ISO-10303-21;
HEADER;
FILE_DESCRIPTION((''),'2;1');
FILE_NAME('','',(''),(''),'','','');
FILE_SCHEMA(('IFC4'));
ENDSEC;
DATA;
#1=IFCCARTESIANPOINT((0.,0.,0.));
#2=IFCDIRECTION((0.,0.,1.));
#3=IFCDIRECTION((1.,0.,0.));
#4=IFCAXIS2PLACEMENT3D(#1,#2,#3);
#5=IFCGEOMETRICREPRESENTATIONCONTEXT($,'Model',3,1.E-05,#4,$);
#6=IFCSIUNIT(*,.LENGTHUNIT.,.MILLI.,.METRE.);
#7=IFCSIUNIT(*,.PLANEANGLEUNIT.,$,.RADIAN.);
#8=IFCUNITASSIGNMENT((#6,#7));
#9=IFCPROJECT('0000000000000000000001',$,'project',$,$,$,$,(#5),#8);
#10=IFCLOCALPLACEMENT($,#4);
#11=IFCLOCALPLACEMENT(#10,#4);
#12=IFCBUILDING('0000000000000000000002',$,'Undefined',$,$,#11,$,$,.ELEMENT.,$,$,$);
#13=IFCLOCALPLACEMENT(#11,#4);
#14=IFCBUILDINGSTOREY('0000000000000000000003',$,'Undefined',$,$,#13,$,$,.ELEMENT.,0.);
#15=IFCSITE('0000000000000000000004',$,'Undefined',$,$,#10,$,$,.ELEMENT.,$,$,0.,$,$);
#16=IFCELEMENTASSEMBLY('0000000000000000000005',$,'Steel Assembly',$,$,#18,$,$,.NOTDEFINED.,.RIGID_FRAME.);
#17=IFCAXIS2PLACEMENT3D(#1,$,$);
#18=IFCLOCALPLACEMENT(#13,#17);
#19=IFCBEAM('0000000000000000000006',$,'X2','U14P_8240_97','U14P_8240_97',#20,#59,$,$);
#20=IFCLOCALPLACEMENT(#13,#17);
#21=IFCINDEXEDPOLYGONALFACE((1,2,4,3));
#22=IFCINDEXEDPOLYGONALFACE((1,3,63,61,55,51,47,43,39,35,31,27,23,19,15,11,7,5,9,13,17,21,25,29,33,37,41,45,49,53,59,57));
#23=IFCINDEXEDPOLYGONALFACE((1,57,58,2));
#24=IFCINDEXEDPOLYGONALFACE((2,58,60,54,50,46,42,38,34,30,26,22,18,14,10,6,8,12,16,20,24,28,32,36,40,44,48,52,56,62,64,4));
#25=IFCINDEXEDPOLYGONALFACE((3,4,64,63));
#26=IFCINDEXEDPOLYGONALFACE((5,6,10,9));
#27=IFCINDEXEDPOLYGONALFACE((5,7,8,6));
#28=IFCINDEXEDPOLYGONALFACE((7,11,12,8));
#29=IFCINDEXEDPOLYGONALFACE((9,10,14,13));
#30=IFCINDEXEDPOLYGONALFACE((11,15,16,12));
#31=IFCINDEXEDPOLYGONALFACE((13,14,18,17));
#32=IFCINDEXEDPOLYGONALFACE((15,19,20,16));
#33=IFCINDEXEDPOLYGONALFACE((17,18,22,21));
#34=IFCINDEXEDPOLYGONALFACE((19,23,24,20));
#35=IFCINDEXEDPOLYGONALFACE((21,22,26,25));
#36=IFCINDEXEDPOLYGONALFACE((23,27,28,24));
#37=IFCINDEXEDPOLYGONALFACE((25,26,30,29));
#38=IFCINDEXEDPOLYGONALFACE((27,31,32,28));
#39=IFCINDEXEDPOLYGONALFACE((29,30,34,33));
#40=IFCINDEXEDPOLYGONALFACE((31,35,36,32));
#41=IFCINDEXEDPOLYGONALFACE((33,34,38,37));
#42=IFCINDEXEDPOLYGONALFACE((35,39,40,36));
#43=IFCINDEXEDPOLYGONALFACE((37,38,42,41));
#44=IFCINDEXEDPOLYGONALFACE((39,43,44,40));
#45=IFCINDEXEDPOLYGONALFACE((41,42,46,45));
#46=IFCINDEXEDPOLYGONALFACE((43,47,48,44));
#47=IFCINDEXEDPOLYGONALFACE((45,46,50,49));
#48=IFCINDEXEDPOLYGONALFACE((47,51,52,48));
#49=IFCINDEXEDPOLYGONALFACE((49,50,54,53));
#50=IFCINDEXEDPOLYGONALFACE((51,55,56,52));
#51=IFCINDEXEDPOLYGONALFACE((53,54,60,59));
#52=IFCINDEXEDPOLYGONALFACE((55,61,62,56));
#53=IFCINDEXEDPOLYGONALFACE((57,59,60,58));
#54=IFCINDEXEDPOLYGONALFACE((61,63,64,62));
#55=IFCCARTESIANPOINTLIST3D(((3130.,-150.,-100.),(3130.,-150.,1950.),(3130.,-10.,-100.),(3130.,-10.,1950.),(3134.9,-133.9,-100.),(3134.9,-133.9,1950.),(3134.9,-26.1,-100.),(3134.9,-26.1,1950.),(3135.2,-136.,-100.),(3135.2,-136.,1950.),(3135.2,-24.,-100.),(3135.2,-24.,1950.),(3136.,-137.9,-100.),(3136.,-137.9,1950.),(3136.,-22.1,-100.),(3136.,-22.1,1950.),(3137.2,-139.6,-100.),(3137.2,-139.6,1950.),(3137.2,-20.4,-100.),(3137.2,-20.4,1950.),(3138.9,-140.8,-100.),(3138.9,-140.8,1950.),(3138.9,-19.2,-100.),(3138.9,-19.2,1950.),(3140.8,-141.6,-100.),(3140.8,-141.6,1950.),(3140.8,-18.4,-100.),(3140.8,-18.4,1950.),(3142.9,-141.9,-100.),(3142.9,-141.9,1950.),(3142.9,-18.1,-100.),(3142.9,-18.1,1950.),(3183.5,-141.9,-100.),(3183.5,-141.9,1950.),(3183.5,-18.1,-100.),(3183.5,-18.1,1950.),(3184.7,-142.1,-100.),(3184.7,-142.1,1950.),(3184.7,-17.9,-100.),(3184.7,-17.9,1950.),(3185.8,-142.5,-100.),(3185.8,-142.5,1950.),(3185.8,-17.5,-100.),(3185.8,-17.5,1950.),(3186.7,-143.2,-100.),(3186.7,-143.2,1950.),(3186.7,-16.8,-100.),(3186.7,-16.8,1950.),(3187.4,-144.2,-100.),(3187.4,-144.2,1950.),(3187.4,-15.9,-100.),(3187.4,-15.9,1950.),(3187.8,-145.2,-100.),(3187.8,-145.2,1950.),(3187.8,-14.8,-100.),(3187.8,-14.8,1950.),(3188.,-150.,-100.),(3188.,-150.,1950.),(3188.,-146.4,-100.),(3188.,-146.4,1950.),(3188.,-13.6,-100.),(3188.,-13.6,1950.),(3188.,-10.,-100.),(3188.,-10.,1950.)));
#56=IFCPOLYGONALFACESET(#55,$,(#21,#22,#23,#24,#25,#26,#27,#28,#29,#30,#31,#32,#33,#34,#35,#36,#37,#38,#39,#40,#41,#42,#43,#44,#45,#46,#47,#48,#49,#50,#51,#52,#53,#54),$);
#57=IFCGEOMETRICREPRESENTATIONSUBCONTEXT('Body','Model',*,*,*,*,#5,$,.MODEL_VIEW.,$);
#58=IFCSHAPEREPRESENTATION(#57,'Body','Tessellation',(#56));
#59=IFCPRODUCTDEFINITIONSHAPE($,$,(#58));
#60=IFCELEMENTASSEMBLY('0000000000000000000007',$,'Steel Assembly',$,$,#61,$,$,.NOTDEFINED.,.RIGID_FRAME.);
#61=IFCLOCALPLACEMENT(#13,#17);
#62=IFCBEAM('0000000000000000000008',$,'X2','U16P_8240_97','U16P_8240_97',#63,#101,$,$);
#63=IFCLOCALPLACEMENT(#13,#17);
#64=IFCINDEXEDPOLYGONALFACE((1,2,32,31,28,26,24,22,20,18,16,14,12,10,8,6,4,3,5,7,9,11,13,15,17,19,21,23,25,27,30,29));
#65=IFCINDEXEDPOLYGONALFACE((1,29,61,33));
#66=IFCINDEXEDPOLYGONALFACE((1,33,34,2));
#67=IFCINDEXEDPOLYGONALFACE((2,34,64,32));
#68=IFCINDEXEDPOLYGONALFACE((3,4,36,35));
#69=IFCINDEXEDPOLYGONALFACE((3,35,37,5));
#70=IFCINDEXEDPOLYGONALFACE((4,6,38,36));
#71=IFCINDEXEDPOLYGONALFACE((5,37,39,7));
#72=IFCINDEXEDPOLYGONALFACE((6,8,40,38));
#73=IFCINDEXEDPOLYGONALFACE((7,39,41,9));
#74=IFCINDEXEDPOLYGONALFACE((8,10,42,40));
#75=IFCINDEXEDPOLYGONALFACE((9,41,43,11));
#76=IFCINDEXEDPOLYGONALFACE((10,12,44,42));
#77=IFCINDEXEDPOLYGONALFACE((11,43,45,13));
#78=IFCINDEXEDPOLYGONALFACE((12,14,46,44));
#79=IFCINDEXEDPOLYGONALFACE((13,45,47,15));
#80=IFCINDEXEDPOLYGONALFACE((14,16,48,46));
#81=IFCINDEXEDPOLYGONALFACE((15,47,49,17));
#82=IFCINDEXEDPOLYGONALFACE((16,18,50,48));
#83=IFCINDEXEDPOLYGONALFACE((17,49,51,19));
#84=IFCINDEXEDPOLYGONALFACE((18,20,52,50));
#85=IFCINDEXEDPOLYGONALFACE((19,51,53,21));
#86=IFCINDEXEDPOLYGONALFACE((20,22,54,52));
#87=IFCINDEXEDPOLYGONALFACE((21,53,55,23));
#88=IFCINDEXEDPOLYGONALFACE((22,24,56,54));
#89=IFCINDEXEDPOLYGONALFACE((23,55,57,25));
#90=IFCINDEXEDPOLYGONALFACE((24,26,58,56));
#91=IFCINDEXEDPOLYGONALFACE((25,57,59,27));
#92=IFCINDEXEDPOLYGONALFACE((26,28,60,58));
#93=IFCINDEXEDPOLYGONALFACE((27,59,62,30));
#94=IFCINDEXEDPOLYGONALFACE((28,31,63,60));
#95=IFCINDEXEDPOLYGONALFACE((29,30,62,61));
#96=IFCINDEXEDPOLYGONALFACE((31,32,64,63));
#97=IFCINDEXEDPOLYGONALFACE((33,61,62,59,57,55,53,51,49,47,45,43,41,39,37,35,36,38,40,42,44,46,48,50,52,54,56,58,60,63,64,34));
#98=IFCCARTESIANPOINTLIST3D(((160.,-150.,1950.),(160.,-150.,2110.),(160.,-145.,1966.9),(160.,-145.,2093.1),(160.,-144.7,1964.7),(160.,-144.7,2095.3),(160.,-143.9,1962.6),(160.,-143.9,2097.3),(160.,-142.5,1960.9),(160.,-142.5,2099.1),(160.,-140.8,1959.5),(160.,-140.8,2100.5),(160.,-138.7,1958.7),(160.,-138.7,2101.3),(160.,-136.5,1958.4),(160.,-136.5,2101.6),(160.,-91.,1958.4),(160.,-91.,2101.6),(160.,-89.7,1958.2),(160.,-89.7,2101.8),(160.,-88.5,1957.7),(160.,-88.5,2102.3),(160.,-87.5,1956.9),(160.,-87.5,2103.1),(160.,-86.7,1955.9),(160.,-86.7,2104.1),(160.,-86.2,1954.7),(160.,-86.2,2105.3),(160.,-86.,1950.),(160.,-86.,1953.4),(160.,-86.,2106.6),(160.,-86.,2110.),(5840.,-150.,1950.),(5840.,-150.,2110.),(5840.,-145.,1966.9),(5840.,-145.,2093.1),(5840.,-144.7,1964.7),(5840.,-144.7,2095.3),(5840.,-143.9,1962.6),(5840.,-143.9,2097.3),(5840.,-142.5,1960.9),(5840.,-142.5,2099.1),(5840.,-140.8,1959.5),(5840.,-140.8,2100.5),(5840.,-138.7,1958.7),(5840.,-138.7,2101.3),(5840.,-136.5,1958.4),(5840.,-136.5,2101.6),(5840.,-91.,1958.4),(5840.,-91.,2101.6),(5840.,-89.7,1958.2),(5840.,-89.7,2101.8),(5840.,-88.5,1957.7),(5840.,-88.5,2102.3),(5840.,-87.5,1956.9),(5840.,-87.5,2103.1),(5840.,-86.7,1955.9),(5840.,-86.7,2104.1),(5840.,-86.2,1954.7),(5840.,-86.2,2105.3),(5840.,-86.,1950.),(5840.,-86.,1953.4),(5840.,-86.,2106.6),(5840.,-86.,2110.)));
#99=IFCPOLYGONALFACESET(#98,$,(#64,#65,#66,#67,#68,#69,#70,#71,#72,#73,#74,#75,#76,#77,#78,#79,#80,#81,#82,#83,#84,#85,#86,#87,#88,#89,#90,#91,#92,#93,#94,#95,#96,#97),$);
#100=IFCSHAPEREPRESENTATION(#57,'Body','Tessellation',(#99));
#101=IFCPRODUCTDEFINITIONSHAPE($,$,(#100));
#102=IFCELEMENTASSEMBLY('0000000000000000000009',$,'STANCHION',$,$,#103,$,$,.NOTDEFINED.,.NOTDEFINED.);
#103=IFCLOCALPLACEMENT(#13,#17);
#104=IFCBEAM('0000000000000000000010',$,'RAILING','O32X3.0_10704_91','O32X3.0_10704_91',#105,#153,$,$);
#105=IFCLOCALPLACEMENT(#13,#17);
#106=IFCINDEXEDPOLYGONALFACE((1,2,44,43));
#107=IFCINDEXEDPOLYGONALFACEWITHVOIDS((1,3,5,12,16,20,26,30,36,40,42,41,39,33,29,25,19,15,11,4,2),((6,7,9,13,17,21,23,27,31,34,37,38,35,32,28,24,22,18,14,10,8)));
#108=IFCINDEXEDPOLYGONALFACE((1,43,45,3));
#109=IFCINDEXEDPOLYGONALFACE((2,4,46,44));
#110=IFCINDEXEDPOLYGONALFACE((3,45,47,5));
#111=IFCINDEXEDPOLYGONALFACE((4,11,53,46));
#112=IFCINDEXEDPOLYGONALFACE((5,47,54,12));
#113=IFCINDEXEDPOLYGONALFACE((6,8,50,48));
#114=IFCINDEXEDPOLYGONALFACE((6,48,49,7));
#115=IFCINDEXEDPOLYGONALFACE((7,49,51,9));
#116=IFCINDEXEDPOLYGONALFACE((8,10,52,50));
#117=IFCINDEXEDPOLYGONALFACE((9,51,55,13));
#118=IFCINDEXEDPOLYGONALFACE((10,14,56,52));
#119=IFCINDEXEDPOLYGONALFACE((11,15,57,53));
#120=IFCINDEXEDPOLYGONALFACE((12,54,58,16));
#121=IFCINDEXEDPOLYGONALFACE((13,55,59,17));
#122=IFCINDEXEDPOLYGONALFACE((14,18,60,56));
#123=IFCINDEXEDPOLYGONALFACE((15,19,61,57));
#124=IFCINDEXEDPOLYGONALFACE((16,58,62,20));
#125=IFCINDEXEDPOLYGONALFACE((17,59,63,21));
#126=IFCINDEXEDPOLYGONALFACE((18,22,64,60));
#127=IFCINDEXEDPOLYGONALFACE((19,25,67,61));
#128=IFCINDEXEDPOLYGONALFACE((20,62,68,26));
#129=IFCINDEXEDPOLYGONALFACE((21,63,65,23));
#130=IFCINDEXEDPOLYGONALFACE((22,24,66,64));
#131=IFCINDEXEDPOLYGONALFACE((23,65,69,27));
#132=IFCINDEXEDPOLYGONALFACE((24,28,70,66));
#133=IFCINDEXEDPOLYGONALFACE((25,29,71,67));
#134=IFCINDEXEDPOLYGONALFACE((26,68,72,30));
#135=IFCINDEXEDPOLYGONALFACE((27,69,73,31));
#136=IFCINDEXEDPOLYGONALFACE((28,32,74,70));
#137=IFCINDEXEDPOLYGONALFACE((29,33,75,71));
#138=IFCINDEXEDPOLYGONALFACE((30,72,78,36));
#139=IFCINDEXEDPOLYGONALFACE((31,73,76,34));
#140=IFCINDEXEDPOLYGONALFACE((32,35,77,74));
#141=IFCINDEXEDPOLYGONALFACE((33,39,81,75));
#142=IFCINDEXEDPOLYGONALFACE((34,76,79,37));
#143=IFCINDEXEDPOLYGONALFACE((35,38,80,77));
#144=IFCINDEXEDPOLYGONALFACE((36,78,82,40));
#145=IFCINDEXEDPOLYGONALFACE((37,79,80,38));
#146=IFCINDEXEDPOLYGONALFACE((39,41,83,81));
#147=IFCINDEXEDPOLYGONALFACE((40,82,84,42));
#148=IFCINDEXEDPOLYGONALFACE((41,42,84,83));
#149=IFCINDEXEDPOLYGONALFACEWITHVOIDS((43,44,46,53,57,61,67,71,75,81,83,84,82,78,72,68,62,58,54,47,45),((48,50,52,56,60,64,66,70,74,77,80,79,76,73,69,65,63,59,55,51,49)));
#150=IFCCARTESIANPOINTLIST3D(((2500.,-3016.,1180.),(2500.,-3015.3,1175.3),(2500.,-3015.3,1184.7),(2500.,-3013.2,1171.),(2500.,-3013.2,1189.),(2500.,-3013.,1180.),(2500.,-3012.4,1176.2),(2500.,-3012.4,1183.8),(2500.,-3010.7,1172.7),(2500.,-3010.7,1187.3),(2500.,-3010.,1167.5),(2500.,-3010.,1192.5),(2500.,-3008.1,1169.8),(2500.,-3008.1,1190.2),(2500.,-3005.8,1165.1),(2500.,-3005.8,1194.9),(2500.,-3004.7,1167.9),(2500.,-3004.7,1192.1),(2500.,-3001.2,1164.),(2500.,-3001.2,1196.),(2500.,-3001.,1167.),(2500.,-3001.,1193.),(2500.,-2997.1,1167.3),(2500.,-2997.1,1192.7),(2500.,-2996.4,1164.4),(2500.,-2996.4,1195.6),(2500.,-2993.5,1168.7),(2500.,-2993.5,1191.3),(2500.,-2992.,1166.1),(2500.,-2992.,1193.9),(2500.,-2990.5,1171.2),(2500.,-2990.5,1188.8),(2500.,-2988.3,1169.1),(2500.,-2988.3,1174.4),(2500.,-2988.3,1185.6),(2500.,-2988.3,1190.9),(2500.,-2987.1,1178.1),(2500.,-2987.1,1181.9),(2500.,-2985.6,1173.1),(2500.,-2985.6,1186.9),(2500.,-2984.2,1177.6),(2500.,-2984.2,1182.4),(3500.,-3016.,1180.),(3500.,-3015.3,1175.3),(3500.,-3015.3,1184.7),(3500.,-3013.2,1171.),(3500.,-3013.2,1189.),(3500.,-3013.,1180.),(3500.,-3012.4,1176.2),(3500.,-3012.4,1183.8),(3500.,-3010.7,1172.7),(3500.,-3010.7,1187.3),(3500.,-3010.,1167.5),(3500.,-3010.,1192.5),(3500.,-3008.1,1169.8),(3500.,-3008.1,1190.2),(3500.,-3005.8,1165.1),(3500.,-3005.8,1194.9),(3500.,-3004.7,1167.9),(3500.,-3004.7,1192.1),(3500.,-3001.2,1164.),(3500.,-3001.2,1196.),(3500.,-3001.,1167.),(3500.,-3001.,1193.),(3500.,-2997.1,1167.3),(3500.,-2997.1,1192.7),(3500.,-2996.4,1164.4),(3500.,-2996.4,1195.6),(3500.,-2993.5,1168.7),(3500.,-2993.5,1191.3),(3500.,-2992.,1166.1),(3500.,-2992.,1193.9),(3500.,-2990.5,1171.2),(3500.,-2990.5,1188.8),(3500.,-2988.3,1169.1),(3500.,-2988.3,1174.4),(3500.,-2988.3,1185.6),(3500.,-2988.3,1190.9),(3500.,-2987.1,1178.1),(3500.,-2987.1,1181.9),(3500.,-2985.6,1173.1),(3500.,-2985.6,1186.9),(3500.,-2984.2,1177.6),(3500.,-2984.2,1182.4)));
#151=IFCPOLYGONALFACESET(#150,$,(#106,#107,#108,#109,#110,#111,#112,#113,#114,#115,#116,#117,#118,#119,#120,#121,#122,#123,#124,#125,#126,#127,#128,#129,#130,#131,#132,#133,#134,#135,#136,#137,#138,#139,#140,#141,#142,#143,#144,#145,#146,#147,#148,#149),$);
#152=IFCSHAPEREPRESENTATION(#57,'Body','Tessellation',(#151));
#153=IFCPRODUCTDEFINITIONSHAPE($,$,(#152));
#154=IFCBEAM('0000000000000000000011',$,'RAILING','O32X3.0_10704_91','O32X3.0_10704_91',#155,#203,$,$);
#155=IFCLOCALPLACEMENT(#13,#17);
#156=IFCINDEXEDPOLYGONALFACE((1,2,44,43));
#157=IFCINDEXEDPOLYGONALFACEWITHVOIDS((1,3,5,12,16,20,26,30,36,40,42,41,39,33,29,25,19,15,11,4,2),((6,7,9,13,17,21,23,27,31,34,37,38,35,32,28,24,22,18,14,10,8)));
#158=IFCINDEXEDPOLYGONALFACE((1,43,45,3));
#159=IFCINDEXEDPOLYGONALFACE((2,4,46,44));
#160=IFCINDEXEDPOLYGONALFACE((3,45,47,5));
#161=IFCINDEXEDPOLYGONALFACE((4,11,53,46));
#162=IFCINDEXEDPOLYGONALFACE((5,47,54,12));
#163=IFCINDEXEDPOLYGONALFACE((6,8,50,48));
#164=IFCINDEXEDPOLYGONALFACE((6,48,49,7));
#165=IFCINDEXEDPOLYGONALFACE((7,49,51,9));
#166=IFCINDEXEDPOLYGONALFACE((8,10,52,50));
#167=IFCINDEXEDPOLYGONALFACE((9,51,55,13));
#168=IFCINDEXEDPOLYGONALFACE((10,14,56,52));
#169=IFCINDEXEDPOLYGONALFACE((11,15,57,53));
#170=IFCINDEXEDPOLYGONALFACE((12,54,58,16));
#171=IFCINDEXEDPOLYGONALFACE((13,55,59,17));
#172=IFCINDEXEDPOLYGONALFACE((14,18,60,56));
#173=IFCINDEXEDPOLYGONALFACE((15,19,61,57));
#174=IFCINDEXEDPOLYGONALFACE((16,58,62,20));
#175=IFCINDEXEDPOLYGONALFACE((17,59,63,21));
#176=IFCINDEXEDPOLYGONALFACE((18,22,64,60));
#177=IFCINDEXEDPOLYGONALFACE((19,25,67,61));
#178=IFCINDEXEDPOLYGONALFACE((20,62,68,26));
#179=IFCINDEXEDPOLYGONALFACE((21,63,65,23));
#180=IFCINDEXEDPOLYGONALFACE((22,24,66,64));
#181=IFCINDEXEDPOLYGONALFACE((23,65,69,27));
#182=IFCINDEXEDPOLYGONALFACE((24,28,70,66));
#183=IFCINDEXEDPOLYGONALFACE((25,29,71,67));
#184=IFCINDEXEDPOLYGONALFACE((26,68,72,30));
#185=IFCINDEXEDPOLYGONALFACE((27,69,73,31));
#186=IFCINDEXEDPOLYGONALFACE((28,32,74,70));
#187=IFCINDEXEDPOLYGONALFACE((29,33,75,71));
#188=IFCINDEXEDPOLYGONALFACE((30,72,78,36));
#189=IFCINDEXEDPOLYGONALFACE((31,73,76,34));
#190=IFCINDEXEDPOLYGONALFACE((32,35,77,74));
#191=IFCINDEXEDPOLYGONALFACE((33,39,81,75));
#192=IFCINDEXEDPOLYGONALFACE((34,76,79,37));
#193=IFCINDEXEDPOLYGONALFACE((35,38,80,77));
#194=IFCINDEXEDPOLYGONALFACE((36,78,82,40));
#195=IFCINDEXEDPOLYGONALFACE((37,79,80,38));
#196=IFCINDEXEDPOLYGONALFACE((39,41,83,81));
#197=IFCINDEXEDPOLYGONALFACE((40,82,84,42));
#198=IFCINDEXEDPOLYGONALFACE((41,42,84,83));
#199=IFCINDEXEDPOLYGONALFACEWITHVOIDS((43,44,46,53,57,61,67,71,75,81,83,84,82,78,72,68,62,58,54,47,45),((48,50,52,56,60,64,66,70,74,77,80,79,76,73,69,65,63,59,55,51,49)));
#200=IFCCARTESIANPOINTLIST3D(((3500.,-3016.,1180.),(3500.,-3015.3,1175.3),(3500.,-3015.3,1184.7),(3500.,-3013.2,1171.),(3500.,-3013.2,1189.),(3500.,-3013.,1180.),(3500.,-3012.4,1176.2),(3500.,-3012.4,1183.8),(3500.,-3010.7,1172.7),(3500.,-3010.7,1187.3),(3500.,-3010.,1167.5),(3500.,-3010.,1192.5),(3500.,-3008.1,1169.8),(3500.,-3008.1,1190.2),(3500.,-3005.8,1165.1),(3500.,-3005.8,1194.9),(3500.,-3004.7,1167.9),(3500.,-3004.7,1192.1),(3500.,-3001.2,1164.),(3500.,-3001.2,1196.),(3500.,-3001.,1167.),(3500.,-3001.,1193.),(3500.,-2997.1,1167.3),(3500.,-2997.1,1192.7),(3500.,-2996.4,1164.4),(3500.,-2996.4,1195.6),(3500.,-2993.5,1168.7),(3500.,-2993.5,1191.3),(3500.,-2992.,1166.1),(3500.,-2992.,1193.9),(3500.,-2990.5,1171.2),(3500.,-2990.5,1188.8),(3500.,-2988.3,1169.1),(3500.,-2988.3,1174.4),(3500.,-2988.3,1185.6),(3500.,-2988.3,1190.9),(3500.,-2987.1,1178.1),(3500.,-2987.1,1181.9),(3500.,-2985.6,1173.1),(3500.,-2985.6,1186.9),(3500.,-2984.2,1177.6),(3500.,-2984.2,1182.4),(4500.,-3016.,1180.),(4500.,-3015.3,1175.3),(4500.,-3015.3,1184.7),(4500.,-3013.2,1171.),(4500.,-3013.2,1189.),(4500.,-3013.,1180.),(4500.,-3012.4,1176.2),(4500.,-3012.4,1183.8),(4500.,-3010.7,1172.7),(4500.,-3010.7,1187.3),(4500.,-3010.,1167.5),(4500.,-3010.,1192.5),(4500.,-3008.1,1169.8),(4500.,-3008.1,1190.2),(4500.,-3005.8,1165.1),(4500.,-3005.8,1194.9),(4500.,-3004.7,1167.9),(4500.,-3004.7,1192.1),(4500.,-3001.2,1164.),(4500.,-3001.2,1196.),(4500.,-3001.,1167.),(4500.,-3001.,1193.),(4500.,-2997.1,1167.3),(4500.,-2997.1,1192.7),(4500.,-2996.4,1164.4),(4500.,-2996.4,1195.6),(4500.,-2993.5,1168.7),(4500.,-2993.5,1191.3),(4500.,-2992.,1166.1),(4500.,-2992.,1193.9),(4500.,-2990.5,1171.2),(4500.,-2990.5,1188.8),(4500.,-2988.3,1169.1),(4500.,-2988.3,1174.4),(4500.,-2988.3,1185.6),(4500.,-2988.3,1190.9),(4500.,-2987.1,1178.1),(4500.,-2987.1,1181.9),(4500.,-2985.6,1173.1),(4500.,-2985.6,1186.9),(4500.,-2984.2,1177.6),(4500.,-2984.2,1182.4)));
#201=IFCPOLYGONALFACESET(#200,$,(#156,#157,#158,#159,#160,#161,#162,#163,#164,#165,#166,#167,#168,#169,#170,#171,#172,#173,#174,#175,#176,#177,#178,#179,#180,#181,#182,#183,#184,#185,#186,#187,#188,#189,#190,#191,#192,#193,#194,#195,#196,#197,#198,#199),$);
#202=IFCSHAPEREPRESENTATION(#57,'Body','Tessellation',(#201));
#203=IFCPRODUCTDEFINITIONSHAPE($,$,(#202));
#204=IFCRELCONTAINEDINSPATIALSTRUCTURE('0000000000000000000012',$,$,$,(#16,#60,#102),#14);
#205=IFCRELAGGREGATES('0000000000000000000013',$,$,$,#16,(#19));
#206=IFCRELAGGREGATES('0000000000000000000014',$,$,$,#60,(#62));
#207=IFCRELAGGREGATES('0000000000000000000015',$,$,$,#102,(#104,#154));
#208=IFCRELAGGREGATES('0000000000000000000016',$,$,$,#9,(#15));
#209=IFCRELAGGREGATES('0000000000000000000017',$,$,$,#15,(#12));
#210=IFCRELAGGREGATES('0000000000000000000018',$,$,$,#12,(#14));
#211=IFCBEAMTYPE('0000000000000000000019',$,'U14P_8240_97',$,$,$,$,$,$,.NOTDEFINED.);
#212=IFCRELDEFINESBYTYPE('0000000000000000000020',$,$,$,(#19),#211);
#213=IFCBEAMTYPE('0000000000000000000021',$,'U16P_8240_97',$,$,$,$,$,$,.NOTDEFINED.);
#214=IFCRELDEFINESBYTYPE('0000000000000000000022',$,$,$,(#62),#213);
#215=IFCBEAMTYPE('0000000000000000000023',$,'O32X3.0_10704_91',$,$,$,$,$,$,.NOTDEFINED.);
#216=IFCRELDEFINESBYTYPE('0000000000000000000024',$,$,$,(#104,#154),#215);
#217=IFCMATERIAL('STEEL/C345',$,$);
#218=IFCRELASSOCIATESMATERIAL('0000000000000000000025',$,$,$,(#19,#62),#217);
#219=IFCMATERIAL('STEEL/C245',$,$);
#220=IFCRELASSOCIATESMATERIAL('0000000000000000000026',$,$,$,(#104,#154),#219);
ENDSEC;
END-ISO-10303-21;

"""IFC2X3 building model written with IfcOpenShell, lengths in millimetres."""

from ifc_helpers import new_model, si_unit, frame, origin_with_axes, origin_2d_with_axis, place, context, subcontext, project, spatial, hollow_circle, u_section, extrude, material, type_object, element, aggregate, save


model = new_model("IFC2X3")

# Units and contexts
model_context = context("Model", 3, precision=1e-05, world=origin_with_axes())
body_context = subcontext(model_context, "Body", "Model", "MODEL_VIEW")
ifc_project = project(units=[si_unit("LENGTHUNIT", "METRE", prefix="MILLI"), si_unit("PLANEANGLEUNIT", "RADIAN")], contexts=[model_context])

# Site, building, storey
site_placement = place(None, origin_with_axes())
site = spatial("IfcSite", under=ifc_project, at=site_placement, Name="Undefined", CompositionType="ELEMENT", RefElevation=0.0)
building_placement = place(site_placement, origin_with_axes())
building = spatial("IfcBuilding", under=site, at=building_placement, Name="Undefined", CompositionType="ELEMENT")
storey_placement = place(building_placement, origin_with_axes())
storey = spatial("IfcBuildingStorey", under=building, at=storey_placement, Name="Undefined", CompositionType="ELEMENT", Elevation=0.0)

# Element assemblies, beams
assembly_1_placement = place(storey_placement, origin_with_axes())
assembly_1 = element("IfcElementAssembly", 1, at=assembly_1_placement, inside=storey, Name="Steel Assembly", AssemblyPlace="NOTDEFINED", PredefinedType="RIGID_FRAME")
ifc_material_1 = material(Name="STEEL/C345")
beam_type_1 = type_object("IfcBeamType", Name="U14P_8240_97", PredefinedType="NOTDEFINED")
beam_1_placement = place(assembly_1_placement, frame((3159.0, -80.0, 1950.0), z_axis=(0.0, 1.0, 0.0), x_axis=(0.0, 0.0, -1.0)))
beam_1 = element("IfcBeam", 2, at=beam_1_placement, type_object=beam_type_1, material=ifc_material_1, Name="X2", Description="U14P_8240_97", ObjectType="U14P_8240_97", context=body_context, shape_type="SweptSolid", body=[
    extrude(u_section(Depth=140.0, FlangeWidth=58.0, WebThickness=4.9, FlangeThickness=8.1, FilletRadius=8.0, EdgeRadius=4.5, at=origin_2d_with_axis()), frame((2050.0, 0.0, 0.0), z_axis=(-1.0, 0.0, 0.0), x_axis=(0.0, -1.0, 0.0)), (0.0, 0.0, 1.0), 2050.0),
])
aggregate(assembly_1, [beam_1])
assembly_2_placement = place(storey_placement, origin_with_axes())
assembly_2 = element("IfcElementAssembly", 3, at=assembly_2_placement, inside=storey, Name="Steel Assembly", AssemblyPlace="NOTDEFINED", PredefinedType="RIGID_FRAME")
beam_type_2 = type_object("IfcBeamType", Name="U16P_8240_97", PredefinedType="NOTDEFINED")
beam_2_placement = place(assembly_2_placement, frame((5840.0, -118.0, 2030.0), z_axis=(0.0, 0.0, 1.0), x_axis=(-1.0, 0.0, 0.0)))
beam_2 = element("IfcBeam", 4, at=beam_2_placement, type_object=beam_type_2, material=ifc_material_1, Name="X2", Description="U16P_8240_97", ObjectType="U16P_8240_97", context=body_context, shape_type="SweptSolid", body=[
    extrude(u_section(Depth=160.0, FlangeWidth=64.0, WebThickness=5.0, FlangeThickness=8.4, FilletRadius=8.5, EdgeRadius=5.0, at=origin_2d_with_axis()), frame((5680.0, 0.0, 0.0), z_axis=(-1.0, 0.0, 0.0), x_axis=(0.0, -1.0, 0.0)), (0.0, 0.0, 1.0), 5680.0),
])
aggregate(assembly_2, [beam_2])

# Element assembly, beams
assembly_3_placement = place(storey_placement, origin_with_axes())
assembly_3 = element("IfcElementAssembly", 5, at=assembly_3_placement, inside=storey, Name="STANCHION", AssemblyPlace="NOTDEFINED", PredefinedType="NOTDEFINED")
ifc_material_2 = material(Name="STEEL/C245")
beam_type_3 = type_object("IfcBeamType", Name="O32X3.0_10704_91", PredefinedType="NOTDEFINED")
beam_3_placement = place(assembly_3_placement, frame((3500.0, -3000.0, 1180.0), z_axis=(0.0, 0.0, -1.0), x_axis=(-1.0, 0.0, 0.0)))
beam_3 = element("IfcBeam", 6, at=beam_3_placement, type_object=beam_type_3, material=ifc_material_2, Name="RAILING", Description="O32X3.0_10704_91", ObjectType="O32X3.0_10704_91", context=body_context, shape_type="SweptSolid", body=[
    extrude(hollow_circle(Radius=16.0, WallThickness=3.0, at=origin_2d_with_axis()), frame((1000.0, 0.0, 0.0), z_axis=(-1.0, 0.0, 0.0), x_axis=(0.0, -1.0, 0.0)), (0.0, 0.0, 1.0), 1000.0),
])
beam_4_placement = place(assembly_3_placement, frame((4500.0, -3000.0, 1180.0), z_axis=(0.0, 0.0, -1.0), x_axis=(-1.0, 0.0, 0.0)))
beam_4 = element("IfcBeam", 7, at=beam_4_placement, type_object=beam_type_3, material=ifc_material_2, Name="RAILING", Description="O32X3.0_10704_91", ObjectType="O32X3.0_10704_91", context=body_context, shape_type="SweptSolid", body=[
    extrude(hollow_circle(Radius=16.0, WallThickness=3.0, at=origin_2d_with_axis()), frame((1000.0, 0.0, 0.0), z_axis=(-1.0, 0.0, 0.0), x_axis=(0.0, -1.0, 0.0)), (0.0, 0.0, 1.0), 1000.0),
])
aggregate(assembly_3, [beam_3, beam_4])

save(model, "model.ifc")
